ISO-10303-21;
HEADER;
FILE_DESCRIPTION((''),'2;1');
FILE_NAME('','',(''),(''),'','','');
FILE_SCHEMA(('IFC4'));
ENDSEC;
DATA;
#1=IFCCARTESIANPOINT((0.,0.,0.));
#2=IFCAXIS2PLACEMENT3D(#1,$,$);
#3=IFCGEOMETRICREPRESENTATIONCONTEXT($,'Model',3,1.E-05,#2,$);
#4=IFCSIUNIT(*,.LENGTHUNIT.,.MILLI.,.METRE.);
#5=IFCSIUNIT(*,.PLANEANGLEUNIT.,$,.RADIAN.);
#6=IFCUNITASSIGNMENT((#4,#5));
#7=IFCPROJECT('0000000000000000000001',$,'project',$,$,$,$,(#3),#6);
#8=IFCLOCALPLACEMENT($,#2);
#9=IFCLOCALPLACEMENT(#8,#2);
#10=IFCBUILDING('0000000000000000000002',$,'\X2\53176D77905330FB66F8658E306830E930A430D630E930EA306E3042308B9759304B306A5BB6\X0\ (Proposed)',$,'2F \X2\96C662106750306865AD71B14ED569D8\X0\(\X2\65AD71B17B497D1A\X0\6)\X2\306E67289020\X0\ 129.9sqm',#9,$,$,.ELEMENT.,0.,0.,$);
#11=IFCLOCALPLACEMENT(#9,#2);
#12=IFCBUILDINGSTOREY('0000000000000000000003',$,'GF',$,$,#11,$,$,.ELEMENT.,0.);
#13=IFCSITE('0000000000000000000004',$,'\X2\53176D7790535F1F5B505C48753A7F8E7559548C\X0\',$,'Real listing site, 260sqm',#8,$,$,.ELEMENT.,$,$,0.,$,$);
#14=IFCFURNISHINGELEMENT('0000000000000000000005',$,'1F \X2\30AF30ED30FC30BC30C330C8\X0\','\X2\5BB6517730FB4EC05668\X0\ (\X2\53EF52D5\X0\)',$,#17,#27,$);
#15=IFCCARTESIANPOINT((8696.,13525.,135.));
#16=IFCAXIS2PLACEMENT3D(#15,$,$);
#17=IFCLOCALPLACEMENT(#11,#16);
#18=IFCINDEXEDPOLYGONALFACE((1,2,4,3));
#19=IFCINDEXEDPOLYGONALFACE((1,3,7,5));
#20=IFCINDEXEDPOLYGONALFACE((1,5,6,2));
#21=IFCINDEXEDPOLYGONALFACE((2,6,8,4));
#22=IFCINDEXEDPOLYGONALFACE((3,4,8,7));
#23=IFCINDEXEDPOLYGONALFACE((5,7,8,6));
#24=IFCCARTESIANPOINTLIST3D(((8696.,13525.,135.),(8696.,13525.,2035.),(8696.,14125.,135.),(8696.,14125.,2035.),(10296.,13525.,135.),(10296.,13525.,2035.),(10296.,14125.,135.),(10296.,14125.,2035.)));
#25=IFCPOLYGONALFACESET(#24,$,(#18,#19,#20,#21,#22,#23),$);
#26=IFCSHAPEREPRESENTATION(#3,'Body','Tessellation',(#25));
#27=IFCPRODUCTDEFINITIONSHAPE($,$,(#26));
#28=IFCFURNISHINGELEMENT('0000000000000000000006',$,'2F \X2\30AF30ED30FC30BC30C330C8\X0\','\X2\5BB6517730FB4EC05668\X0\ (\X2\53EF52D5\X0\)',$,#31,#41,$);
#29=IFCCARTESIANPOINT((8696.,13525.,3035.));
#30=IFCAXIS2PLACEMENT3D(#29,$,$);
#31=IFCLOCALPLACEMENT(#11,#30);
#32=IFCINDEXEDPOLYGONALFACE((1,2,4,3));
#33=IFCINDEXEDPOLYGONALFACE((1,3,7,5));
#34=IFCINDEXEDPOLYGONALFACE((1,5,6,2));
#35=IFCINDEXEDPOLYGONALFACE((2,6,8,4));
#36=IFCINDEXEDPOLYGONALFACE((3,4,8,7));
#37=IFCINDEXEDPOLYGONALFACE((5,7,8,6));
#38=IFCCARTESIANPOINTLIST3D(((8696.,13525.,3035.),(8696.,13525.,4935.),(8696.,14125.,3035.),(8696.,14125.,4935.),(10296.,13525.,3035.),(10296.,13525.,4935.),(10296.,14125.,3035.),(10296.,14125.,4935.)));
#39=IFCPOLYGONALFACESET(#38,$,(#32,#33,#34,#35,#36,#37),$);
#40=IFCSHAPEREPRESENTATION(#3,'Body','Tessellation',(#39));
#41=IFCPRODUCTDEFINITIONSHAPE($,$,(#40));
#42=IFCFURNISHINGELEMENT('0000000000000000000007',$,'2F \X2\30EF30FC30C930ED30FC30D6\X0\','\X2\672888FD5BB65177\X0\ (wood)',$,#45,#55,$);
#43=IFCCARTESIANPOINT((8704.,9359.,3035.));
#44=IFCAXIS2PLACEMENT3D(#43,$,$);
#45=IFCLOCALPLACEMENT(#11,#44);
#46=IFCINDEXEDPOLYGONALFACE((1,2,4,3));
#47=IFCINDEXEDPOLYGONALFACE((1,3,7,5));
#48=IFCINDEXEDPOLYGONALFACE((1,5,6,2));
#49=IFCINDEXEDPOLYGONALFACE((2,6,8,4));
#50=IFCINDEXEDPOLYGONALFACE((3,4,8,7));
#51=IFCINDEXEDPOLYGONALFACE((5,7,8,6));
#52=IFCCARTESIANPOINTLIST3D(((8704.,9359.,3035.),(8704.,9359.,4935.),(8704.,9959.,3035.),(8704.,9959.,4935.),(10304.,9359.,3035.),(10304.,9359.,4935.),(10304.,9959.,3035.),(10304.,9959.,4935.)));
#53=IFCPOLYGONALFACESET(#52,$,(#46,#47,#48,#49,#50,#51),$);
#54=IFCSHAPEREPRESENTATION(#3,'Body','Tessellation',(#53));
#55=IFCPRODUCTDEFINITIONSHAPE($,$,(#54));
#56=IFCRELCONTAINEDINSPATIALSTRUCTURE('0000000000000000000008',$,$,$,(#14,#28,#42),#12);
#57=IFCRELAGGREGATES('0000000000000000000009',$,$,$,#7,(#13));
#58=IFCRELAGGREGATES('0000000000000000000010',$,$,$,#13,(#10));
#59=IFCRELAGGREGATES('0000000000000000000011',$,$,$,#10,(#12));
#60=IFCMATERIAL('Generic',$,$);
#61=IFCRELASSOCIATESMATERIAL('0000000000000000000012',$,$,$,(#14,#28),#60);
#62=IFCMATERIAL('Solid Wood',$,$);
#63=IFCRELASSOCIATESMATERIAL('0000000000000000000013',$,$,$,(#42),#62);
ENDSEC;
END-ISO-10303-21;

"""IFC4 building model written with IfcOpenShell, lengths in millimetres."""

from ifc_helpers import new_model, si_unit, frame, frame_2d, origin, place, context, project, spatial, rectangle, extrude, material, element, save


model = new_model("IFC4")

# Units and contexts
model_context = context("Model", 3, precision=1e-05, world=origin())
ifc_project = project(units=[si_unit("LENGTHUNIT", "METRE", prefix="MILLI"), si_unit("PLANEANGLEUNIT", "RADIAN")], contexts=[model_context])

# Site, building, storey
site_placement = place(None, origin())
site = spatial("IfcSite", under=ifc_project, at=site_placement, Name="北海道弟子屈町美留和", ObjectType="Real listing site, 260sqm", CompositionType="ELEMENT", RefElevation=0.0)
building_placement = place(site_placement, origin())
building = spatial("IfcBuilding", under=site, at=building_placement, Name="北海道・書斎とライブラリのある静かな家 (Proposed)", ObjectType="2F 集成材と断熱仕様(断熱等級6)の木造 129.9sqm", CompositionType="ELEMENT", ElevationOfRefHeight=0.0, ElevationOfTerrain=0.0)
storey_placement = place(building_placement, origin())
storey = spatial("IfcBuildingStorey", under=building, at=storey_placement, Name="GF", CompositionType="ELEMENT", Elevation=0.0)

# Shared definitions
ifc_material_1 = material(Name="Solid Wood")

# Shared definitions
ifc_material_2 = material(Name="Generic")

# Furnishing elements
furnishing_1_placement = place(storey_placement, frame((8696.0, 13525.0, 135.0)))
element("IfcFurnishingElement", 1, at=furnishing_1_placement, inside=storey, material=ifc_material_2, Name="1F クローゼット", Description="家具・什器 (可動)", context=model_context, shape_type="SweptSolid", body=[
    extrude(rectangle(XDim=1600.0, YDim=600.0, at=frame_2d((800.0, 300.0))), frame((8696.0, 13525.0, 135.0)), (0.0, 0.0, 1.0), 1900.0),
])
furnishing_2_placement = place(storey_placement, frame((8696.0, 13525.0, 3035.0)))
element("IfcFurnishingElement", 2, at=furnishing_2_placement, inside=storey, material=ifc_material_2, Name="2F クローゼット", Description="家具・什器 (可動)", context=model_context, shape_type="SweptSolid", body=[
    extrude(rectangle(XDim=1600.0, YDim=600.0, at=frame_2d((800.0, 300.0))), frame((8696.0, 13525.0, 3035.0)), (0.0, 0.0, 1.0), 1900.0),
])
furnishing_3_placement = place(storey_placement, frame((8704.0, 9359.0, 3035.0)))
element("IfcFurnishingElement", 3, at=furnishing_3_placement, inside=storey, material=ifc_material_1, Name="2F ワードローブ", Description="木製家具 (wood)", context=model_context, shape_type="SweptSolid", body=[
    extrude(rectangle(XDim=1600.0, YDim=600.0, at=frame_2d((800.0, 300.0))), frame((8704.0, 9359.0, 3035.0)), (0.0, 0.0, 1.0), 1900.0),
])

save(model, "model.ifc")
